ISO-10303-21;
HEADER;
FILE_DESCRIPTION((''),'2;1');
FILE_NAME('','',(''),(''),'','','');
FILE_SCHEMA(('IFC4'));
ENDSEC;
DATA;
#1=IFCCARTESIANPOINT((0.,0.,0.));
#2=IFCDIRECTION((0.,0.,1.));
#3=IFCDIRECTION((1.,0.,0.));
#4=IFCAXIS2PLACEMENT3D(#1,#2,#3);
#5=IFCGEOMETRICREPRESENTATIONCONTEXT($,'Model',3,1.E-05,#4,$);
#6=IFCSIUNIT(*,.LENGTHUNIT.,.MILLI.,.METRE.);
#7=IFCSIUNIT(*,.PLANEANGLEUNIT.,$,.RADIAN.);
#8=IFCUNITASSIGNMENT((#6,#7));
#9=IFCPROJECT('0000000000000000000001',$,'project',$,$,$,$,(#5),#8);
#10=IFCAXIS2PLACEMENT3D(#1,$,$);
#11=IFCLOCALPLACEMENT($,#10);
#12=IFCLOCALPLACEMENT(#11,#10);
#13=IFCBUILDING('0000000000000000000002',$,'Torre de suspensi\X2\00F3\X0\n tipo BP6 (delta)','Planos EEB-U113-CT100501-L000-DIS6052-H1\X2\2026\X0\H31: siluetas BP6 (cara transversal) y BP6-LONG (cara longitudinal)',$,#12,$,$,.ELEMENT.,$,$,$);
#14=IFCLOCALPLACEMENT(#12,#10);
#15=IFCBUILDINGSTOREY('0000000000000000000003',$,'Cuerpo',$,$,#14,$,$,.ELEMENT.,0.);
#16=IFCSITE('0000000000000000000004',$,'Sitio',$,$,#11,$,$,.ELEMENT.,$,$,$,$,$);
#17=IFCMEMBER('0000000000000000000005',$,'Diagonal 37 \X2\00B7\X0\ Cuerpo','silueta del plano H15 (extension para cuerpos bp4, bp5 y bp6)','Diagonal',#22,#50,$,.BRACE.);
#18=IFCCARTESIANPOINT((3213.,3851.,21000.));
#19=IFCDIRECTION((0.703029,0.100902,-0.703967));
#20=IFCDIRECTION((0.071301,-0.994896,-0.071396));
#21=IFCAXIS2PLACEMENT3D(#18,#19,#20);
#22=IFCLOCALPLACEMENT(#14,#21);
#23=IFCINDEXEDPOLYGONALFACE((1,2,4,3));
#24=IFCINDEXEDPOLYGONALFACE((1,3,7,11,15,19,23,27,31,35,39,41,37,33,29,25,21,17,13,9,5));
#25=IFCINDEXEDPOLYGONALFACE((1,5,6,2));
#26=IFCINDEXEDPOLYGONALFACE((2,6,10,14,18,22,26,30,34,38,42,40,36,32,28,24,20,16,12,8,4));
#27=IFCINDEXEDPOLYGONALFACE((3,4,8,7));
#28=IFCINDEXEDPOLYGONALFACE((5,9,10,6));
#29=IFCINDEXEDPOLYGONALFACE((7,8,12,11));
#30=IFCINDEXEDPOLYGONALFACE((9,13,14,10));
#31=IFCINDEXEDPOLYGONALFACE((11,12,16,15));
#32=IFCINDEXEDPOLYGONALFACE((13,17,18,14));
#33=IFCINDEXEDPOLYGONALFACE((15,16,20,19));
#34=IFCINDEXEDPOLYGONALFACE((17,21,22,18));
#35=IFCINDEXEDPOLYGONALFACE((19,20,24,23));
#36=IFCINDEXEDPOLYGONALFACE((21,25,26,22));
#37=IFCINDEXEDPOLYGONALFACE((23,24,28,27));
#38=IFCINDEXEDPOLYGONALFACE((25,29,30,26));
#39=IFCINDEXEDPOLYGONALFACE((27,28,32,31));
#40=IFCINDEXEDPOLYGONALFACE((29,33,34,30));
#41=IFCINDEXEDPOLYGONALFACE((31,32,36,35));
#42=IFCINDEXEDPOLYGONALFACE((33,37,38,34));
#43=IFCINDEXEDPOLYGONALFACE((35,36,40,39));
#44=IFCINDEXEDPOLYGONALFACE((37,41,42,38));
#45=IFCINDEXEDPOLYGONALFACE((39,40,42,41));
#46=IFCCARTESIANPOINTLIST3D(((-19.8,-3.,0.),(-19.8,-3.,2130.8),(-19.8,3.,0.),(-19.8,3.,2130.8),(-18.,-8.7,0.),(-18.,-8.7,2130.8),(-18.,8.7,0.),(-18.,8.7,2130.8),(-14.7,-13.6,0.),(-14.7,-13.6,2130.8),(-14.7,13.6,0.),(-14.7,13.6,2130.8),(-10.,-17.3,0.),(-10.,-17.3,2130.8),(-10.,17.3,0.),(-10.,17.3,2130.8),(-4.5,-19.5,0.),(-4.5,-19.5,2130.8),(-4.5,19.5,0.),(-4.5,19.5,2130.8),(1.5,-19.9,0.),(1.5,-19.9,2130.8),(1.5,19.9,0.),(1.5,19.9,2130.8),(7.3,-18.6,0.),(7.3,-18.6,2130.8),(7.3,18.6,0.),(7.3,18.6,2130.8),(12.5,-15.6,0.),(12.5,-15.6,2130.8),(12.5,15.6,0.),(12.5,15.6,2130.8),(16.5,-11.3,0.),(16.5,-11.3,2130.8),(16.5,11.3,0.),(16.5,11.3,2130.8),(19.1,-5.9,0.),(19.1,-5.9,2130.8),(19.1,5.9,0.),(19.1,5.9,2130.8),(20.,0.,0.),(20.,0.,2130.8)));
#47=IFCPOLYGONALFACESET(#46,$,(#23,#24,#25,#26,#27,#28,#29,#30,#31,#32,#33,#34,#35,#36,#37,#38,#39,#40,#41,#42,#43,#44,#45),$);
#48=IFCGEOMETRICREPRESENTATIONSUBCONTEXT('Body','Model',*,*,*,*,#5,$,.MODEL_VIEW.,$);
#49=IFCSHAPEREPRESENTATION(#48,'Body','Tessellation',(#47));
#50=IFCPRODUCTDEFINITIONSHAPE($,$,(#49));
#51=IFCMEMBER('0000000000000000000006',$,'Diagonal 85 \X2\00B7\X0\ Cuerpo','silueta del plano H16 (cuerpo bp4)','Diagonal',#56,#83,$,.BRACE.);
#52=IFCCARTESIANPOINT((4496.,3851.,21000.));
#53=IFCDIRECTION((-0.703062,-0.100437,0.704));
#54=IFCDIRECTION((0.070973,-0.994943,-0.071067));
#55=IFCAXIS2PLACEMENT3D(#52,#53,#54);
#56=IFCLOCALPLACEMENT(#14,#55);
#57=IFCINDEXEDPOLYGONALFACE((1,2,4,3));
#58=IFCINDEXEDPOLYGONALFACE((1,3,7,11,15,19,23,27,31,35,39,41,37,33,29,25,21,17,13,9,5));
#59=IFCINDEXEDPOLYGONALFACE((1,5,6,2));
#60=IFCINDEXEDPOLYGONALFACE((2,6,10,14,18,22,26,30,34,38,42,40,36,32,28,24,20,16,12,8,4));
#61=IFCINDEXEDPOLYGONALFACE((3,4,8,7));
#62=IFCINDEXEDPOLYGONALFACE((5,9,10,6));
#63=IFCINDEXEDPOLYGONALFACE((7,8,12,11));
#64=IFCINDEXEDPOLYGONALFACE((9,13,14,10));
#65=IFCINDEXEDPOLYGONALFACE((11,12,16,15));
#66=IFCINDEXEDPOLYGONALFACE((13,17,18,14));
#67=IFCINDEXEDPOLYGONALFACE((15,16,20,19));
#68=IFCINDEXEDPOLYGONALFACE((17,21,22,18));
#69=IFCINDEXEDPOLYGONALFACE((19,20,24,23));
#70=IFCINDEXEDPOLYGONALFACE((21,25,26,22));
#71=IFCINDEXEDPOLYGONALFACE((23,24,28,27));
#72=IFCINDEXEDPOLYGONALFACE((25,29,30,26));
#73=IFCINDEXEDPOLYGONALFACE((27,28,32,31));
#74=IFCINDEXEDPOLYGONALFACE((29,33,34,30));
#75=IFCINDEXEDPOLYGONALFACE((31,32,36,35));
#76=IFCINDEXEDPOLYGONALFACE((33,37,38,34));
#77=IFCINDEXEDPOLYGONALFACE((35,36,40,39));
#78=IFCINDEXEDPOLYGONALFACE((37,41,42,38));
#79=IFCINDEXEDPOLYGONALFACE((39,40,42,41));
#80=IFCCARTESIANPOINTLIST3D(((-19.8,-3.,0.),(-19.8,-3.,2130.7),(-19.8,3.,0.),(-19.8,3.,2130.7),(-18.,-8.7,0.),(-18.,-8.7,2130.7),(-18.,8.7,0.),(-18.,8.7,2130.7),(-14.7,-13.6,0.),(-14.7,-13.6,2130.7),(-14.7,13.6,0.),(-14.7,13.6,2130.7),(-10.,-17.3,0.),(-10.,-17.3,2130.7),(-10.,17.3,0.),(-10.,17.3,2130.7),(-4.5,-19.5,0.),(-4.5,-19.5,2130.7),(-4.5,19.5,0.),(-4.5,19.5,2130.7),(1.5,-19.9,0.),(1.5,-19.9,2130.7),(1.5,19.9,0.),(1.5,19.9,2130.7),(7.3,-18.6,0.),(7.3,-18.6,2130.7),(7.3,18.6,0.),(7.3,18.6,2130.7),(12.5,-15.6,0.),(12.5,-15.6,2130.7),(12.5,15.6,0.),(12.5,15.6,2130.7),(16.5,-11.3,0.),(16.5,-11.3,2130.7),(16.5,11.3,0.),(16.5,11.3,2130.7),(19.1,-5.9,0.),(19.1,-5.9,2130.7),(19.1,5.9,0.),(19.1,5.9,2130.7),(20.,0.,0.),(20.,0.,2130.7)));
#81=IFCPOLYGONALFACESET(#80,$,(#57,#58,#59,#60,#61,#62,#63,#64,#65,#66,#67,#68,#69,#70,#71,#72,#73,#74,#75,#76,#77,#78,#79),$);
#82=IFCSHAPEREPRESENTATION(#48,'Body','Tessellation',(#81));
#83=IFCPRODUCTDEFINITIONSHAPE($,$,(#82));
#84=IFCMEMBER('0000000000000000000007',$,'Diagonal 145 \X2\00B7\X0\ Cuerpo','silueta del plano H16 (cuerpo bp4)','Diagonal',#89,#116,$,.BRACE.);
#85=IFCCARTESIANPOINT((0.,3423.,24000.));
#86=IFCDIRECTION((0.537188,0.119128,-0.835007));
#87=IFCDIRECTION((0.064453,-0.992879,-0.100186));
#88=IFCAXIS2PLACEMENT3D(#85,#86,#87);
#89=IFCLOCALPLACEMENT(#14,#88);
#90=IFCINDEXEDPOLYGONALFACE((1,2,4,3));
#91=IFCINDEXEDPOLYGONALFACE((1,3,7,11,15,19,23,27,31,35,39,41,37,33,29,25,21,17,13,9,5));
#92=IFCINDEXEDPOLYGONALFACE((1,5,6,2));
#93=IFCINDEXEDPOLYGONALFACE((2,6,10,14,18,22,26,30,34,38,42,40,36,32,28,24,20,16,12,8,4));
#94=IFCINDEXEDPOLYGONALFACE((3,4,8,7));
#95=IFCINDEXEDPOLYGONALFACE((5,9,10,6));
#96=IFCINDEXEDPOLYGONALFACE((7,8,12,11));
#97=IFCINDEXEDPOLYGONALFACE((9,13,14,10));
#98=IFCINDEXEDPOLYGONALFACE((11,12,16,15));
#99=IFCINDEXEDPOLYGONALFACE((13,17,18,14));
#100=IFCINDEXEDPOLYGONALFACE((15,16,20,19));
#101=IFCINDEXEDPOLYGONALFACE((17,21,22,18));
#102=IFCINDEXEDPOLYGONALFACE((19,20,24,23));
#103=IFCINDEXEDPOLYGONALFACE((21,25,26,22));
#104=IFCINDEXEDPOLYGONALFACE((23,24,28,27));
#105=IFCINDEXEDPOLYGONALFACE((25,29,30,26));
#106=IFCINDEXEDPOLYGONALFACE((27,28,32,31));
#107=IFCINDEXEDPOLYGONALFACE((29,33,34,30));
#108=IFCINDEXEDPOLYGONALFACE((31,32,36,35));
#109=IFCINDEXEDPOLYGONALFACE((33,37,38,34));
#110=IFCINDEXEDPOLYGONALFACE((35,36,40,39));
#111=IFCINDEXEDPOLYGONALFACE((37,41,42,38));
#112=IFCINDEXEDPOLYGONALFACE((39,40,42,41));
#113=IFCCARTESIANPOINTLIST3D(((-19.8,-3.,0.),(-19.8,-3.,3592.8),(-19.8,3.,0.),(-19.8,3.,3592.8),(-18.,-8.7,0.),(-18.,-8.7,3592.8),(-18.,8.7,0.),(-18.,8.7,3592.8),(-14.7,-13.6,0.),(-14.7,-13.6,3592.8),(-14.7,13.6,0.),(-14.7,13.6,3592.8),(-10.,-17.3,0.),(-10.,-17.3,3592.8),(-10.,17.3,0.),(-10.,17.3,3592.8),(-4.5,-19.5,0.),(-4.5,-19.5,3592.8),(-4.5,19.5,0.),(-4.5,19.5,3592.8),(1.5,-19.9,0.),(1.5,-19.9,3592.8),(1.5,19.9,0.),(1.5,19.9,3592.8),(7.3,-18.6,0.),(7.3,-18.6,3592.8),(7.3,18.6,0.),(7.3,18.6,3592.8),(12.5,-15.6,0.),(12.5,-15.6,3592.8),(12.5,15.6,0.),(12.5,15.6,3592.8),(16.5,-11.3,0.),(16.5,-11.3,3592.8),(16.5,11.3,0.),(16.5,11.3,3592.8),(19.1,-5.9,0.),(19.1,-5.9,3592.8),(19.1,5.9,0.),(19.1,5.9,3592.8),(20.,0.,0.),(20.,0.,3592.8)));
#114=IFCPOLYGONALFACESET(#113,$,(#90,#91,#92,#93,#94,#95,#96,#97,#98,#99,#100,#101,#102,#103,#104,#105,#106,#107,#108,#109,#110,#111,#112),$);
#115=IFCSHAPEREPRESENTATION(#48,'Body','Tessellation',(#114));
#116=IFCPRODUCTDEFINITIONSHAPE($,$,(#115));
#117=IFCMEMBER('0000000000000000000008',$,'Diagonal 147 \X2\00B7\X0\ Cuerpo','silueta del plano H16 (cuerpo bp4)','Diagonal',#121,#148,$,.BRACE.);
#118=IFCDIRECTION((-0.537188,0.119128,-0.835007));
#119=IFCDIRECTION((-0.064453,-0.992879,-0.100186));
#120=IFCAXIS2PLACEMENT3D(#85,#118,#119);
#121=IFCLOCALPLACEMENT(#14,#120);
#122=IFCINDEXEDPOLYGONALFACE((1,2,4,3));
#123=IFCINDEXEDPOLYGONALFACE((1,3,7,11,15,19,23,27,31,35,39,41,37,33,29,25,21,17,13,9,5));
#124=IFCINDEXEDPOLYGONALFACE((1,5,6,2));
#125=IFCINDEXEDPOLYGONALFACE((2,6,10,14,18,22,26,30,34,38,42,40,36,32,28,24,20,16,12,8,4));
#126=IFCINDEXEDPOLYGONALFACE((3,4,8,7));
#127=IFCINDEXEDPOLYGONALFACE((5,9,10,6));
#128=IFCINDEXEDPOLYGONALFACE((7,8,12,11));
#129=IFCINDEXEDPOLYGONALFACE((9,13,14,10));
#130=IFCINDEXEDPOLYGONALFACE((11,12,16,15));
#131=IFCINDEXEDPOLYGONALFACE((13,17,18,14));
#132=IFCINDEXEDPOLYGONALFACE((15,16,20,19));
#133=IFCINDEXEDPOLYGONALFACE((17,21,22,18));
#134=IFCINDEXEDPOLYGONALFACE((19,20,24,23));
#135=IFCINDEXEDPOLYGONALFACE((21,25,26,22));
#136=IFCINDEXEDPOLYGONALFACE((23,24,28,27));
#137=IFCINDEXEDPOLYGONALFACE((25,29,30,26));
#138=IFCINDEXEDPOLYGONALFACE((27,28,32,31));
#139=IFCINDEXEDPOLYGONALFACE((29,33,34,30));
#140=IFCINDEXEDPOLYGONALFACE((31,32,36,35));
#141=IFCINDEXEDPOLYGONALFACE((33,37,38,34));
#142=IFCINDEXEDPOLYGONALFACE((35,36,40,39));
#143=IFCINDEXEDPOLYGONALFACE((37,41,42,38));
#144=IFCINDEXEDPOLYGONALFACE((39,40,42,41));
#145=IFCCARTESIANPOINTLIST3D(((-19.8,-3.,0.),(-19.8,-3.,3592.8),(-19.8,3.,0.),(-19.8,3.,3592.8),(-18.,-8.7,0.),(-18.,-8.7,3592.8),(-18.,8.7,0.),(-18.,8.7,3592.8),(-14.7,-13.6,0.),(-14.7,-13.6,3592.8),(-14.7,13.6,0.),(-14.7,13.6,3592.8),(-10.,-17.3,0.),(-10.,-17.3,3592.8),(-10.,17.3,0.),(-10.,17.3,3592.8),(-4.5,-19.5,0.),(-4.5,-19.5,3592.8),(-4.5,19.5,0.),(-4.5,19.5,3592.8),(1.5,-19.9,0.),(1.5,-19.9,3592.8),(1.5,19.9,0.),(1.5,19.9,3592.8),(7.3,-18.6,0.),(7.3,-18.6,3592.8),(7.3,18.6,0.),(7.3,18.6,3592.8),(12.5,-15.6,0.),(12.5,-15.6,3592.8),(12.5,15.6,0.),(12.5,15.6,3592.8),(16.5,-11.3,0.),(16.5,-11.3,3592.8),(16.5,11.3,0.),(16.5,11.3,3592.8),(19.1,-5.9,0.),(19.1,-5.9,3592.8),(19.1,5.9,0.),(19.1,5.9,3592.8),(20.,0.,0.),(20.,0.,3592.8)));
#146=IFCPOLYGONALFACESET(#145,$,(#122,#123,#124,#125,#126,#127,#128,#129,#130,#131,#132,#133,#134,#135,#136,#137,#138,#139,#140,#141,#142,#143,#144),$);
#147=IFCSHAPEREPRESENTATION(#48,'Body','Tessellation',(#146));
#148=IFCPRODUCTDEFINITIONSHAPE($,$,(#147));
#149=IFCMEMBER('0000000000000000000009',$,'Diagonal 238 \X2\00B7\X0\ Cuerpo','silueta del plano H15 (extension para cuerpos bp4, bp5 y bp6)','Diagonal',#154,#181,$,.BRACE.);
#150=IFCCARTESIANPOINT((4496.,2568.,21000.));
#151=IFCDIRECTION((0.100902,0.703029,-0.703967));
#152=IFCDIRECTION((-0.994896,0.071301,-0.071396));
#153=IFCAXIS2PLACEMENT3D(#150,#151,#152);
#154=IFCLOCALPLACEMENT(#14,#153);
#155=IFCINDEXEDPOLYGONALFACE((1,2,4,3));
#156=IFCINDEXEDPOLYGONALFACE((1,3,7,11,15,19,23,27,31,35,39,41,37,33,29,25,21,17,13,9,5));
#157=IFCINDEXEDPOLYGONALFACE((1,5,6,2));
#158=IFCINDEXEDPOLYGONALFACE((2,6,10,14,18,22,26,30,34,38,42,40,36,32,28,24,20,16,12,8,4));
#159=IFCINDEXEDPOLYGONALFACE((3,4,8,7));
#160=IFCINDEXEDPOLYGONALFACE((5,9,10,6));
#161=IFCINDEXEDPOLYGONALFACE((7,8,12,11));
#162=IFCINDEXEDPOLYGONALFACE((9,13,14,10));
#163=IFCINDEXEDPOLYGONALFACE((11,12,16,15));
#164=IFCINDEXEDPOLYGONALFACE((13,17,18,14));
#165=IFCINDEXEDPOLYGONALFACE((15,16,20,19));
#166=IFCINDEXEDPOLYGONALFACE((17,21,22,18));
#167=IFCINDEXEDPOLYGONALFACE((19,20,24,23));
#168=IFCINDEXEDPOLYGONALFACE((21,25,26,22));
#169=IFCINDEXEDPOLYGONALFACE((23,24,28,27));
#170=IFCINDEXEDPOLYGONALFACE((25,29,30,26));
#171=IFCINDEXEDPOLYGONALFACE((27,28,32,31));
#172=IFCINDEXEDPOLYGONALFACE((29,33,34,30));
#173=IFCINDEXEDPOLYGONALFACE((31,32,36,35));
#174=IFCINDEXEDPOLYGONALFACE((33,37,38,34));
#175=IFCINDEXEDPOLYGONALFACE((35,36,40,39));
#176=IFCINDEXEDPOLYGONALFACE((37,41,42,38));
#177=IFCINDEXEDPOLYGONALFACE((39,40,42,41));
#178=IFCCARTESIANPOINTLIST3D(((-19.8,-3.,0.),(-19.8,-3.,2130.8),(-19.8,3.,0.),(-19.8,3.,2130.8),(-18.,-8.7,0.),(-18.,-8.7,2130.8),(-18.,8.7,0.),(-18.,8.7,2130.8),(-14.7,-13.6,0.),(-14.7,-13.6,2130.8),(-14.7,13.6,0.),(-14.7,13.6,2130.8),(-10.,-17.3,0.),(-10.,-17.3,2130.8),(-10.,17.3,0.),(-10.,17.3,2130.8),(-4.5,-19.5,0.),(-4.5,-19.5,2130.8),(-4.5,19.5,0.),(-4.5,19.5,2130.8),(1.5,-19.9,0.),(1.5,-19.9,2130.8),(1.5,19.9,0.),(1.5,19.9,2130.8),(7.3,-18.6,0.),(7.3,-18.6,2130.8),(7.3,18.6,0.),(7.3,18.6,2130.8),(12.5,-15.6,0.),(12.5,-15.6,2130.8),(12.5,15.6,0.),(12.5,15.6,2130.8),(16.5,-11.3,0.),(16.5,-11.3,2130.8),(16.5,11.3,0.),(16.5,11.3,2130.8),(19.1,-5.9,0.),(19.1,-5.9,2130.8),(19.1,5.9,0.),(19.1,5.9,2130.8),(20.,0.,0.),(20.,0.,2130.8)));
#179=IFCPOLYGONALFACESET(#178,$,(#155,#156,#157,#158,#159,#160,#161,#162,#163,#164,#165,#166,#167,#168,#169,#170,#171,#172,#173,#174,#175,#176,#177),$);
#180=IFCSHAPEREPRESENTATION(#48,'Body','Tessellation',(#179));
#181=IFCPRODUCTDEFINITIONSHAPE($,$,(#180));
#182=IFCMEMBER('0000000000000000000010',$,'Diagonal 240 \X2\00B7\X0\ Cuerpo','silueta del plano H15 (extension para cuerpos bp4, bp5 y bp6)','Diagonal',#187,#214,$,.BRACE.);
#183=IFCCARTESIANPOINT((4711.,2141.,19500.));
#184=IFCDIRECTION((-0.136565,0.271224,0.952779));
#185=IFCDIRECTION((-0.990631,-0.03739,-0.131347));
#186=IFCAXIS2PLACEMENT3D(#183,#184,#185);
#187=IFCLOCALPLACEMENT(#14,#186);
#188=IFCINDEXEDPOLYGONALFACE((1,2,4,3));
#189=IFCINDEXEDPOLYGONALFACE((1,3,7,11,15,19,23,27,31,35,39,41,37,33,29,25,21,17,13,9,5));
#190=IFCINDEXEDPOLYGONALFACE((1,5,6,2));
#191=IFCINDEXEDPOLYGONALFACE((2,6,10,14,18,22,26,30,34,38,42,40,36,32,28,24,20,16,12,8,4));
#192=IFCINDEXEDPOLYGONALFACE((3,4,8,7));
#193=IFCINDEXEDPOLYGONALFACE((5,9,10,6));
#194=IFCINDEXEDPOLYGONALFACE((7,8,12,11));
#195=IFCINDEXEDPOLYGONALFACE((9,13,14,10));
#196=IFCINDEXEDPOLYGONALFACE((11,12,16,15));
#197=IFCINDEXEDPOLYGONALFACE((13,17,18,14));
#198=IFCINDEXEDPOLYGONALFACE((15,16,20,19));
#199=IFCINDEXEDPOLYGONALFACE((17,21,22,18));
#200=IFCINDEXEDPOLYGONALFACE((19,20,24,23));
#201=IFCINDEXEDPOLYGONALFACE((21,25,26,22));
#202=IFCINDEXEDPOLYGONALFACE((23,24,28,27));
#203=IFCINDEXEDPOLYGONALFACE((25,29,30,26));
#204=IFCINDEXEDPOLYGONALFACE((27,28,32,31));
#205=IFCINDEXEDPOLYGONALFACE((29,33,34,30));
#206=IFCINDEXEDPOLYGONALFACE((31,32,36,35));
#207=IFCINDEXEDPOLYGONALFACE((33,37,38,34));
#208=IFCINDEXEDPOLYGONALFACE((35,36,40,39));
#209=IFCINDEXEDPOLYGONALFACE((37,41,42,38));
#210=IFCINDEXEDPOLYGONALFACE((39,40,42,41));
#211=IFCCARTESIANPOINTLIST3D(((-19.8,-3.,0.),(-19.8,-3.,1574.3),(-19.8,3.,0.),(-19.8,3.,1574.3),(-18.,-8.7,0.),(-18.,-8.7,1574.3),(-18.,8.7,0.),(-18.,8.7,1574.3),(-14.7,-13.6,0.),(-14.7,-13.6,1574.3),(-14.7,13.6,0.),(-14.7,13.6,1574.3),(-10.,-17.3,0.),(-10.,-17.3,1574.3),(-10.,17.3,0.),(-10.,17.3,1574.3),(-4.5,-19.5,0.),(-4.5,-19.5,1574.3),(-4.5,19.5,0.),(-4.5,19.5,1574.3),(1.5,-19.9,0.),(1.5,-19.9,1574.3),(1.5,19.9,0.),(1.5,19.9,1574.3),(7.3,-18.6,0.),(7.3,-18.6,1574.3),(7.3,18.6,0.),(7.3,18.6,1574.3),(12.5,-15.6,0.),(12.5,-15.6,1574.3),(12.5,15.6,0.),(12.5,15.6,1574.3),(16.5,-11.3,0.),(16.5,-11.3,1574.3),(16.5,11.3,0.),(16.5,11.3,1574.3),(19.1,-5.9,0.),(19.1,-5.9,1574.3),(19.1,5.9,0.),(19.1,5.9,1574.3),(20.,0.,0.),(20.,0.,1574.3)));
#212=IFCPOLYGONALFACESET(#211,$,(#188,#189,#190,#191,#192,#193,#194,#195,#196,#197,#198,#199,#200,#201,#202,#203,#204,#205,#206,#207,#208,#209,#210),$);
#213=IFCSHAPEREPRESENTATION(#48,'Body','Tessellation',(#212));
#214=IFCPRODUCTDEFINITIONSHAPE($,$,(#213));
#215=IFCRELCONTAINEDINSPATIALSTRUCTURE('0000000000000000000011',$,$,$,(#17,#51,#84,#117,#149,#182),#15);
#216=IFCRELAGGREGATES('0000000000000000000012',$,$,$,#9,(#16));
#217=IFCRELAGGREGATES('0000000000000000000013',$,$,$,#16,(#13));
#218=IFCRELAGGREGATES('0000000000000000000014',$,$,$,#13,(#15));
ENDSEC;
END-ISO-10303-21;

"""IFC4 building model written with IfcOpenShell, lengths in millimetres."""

from ifc_helpers import new_model, si_unit, frame, origin, origin_with_axes, place, context, subcontext, project, spatial, circle, extrude, element, save


model = new_model("IFC4")

# Units and contexts
model_context = context("Model", 3, precision=1e-05, world=origin_with_axes())
body_context = subcontext(model_context, "Body", "Model", "MODEL_VIEW")
ifc_project = project(units=[si_unit("LENGTHUNIT", "METRE", prefix="MILLI"), si_unit("PLANEANGLEUNIT", "RADIAN")], contexts=[model_context])

# Site, building, storey
site_placement = place(None, origin())
site = spatial("IfcSite", under=ifc_project, at=site_placement, Name="Sitio", CompositionType="ELEMENT")
building_placement = place(site_placement, origin())
building = spatial("IfcBuilding", under=site, at=building_placement, Name="Torre de suspensión tipo BP6 (delta)", Description="Planos EEB-U113-CT100501-L000-DIS6052-H1…H31: siluetas BP6 (cara transversal) y BP6-LONG (cara longitudinal)", CompositionType="ELEMENT")
storey_placement = place(building_placement, origin())
storey = spatial("IfcBuildingStorey", under=building, at=storey_placement, Name="Cuerpo", CompositionType="ELEMENT", Elevation=0.0)

# Members
member_1_placement = place(storey_placement, frame((3213.0, 3851.0, 21000.0), z_axis=(0.703029, 0.100902, -0.703967), x_axis=(0.071301, -0.994896, -0.071396)))
element("IfcMember", 1, at=member_1_placement, inside=storey, Name="Diagonal 37 · Cuerpo", Description="silueta del plano H15 (extension para cuerpos bp4, bp5 y bp6)", ObjectType="Diagonal", PredefinedType="BRACE", context=body_context, shape_type="SweptSolid", body=[
    extrude(circle(Radius=20.0), None, (0.0, 0.0, 1.0), 2130.8),
])
member_2_placement = place(storey_placement, frame((4496.0, 3851.0, 21000.0), z_axis=(-0.703062, -0.100437, 0.704), x_axis=(0.070973, -0.994943, -0.071067)))
element("IfcMember", 2, at=member_2_placement, inside=storey, Name="Diagonal 85 · Cuerpo", Description="silueta del plano H16 (cuerpo bp4)", ObjectType="Diagonal", PredefinedType="BRACE", context=body_context, shape_type="SweptSolid", body=[
    extrude(circle(Radius=20.0), None, (0.0, 0.0, 1.0), 2130.7),
])
for number, where, z_axis, x_axis, name in (
    (3, (0.0, 3423.0, 24000.0), (0.537188, 0.119128, -0.835007), (0.064453, -0.992879, -0.100186), "Diagonal 145 · Cuerpo"),
    (4, (0.0, 3423.0, 24000.0), (-0.537188, 0.119128, -0.835007), (-0.064453, -0.992879, -0.100186), "Diagonal 147 · Cuerpo"),
):
    element("IfcMember", number, at=place(storey_placement, frame(where, z_axis=z_axis, x_axis=x_axis)), inside=storey, Name=name, Description="silueta del plano H16 (cuerpo bp4)", ObjectType="Diagonal", PredefinedType="BRACE", context=body_context, shape_type="SweptSolid", body=[
        extrude(circle(Radius=20.0), None, (0.0, 0.0, 1.0), 3592.8),
    ])
member_3_placement = place(storey_placement, frame((4496.0, 2568.0, 21000.0), z_axis=(0.100902, 0.703029, -0.703967), x_axis=(-0.994896, 0.071301, -0.071396)))
element("IfcMember", 5, at=member_3_placement, inside=storey, Name="Diagonal 238 · Cuerpo", Description="silueta del plano H15 (extension para cuerpos bp4, bp5 y bp6)", ObjectType="Diagonal", PredefinedType="BRACE", context=body_context, shape_type="SweptSolid", body=[
    extrude(circle(Radius=20.0), None, (0.0, 0.0, 1.0), 2130.8),
])
member_4_placement = place(storey_placement, frame((4711.0, 2141.0, 19500.0), z_axis=(-0.136565, 0.271224, 0.952779), x_axis=(-0.990631, -0.03739, -0.131347)))
element("IfcMember", 6, at=member_4_placement, inside=storey, Name="Diagonal 240 · Cuerpo", Description="silueta del plano H15 (extension para cuerpos bp4, bp5 y bp6)", ObjectType="Diagonal", PredefinedType="BRACE", context=body_context, shape_type="SweptSolid", body=[
    extrude(circle(Radius=20.0), None, (0.0, 0.0, 1.0), 1574.3),
])

save(model, "model.ifc")
